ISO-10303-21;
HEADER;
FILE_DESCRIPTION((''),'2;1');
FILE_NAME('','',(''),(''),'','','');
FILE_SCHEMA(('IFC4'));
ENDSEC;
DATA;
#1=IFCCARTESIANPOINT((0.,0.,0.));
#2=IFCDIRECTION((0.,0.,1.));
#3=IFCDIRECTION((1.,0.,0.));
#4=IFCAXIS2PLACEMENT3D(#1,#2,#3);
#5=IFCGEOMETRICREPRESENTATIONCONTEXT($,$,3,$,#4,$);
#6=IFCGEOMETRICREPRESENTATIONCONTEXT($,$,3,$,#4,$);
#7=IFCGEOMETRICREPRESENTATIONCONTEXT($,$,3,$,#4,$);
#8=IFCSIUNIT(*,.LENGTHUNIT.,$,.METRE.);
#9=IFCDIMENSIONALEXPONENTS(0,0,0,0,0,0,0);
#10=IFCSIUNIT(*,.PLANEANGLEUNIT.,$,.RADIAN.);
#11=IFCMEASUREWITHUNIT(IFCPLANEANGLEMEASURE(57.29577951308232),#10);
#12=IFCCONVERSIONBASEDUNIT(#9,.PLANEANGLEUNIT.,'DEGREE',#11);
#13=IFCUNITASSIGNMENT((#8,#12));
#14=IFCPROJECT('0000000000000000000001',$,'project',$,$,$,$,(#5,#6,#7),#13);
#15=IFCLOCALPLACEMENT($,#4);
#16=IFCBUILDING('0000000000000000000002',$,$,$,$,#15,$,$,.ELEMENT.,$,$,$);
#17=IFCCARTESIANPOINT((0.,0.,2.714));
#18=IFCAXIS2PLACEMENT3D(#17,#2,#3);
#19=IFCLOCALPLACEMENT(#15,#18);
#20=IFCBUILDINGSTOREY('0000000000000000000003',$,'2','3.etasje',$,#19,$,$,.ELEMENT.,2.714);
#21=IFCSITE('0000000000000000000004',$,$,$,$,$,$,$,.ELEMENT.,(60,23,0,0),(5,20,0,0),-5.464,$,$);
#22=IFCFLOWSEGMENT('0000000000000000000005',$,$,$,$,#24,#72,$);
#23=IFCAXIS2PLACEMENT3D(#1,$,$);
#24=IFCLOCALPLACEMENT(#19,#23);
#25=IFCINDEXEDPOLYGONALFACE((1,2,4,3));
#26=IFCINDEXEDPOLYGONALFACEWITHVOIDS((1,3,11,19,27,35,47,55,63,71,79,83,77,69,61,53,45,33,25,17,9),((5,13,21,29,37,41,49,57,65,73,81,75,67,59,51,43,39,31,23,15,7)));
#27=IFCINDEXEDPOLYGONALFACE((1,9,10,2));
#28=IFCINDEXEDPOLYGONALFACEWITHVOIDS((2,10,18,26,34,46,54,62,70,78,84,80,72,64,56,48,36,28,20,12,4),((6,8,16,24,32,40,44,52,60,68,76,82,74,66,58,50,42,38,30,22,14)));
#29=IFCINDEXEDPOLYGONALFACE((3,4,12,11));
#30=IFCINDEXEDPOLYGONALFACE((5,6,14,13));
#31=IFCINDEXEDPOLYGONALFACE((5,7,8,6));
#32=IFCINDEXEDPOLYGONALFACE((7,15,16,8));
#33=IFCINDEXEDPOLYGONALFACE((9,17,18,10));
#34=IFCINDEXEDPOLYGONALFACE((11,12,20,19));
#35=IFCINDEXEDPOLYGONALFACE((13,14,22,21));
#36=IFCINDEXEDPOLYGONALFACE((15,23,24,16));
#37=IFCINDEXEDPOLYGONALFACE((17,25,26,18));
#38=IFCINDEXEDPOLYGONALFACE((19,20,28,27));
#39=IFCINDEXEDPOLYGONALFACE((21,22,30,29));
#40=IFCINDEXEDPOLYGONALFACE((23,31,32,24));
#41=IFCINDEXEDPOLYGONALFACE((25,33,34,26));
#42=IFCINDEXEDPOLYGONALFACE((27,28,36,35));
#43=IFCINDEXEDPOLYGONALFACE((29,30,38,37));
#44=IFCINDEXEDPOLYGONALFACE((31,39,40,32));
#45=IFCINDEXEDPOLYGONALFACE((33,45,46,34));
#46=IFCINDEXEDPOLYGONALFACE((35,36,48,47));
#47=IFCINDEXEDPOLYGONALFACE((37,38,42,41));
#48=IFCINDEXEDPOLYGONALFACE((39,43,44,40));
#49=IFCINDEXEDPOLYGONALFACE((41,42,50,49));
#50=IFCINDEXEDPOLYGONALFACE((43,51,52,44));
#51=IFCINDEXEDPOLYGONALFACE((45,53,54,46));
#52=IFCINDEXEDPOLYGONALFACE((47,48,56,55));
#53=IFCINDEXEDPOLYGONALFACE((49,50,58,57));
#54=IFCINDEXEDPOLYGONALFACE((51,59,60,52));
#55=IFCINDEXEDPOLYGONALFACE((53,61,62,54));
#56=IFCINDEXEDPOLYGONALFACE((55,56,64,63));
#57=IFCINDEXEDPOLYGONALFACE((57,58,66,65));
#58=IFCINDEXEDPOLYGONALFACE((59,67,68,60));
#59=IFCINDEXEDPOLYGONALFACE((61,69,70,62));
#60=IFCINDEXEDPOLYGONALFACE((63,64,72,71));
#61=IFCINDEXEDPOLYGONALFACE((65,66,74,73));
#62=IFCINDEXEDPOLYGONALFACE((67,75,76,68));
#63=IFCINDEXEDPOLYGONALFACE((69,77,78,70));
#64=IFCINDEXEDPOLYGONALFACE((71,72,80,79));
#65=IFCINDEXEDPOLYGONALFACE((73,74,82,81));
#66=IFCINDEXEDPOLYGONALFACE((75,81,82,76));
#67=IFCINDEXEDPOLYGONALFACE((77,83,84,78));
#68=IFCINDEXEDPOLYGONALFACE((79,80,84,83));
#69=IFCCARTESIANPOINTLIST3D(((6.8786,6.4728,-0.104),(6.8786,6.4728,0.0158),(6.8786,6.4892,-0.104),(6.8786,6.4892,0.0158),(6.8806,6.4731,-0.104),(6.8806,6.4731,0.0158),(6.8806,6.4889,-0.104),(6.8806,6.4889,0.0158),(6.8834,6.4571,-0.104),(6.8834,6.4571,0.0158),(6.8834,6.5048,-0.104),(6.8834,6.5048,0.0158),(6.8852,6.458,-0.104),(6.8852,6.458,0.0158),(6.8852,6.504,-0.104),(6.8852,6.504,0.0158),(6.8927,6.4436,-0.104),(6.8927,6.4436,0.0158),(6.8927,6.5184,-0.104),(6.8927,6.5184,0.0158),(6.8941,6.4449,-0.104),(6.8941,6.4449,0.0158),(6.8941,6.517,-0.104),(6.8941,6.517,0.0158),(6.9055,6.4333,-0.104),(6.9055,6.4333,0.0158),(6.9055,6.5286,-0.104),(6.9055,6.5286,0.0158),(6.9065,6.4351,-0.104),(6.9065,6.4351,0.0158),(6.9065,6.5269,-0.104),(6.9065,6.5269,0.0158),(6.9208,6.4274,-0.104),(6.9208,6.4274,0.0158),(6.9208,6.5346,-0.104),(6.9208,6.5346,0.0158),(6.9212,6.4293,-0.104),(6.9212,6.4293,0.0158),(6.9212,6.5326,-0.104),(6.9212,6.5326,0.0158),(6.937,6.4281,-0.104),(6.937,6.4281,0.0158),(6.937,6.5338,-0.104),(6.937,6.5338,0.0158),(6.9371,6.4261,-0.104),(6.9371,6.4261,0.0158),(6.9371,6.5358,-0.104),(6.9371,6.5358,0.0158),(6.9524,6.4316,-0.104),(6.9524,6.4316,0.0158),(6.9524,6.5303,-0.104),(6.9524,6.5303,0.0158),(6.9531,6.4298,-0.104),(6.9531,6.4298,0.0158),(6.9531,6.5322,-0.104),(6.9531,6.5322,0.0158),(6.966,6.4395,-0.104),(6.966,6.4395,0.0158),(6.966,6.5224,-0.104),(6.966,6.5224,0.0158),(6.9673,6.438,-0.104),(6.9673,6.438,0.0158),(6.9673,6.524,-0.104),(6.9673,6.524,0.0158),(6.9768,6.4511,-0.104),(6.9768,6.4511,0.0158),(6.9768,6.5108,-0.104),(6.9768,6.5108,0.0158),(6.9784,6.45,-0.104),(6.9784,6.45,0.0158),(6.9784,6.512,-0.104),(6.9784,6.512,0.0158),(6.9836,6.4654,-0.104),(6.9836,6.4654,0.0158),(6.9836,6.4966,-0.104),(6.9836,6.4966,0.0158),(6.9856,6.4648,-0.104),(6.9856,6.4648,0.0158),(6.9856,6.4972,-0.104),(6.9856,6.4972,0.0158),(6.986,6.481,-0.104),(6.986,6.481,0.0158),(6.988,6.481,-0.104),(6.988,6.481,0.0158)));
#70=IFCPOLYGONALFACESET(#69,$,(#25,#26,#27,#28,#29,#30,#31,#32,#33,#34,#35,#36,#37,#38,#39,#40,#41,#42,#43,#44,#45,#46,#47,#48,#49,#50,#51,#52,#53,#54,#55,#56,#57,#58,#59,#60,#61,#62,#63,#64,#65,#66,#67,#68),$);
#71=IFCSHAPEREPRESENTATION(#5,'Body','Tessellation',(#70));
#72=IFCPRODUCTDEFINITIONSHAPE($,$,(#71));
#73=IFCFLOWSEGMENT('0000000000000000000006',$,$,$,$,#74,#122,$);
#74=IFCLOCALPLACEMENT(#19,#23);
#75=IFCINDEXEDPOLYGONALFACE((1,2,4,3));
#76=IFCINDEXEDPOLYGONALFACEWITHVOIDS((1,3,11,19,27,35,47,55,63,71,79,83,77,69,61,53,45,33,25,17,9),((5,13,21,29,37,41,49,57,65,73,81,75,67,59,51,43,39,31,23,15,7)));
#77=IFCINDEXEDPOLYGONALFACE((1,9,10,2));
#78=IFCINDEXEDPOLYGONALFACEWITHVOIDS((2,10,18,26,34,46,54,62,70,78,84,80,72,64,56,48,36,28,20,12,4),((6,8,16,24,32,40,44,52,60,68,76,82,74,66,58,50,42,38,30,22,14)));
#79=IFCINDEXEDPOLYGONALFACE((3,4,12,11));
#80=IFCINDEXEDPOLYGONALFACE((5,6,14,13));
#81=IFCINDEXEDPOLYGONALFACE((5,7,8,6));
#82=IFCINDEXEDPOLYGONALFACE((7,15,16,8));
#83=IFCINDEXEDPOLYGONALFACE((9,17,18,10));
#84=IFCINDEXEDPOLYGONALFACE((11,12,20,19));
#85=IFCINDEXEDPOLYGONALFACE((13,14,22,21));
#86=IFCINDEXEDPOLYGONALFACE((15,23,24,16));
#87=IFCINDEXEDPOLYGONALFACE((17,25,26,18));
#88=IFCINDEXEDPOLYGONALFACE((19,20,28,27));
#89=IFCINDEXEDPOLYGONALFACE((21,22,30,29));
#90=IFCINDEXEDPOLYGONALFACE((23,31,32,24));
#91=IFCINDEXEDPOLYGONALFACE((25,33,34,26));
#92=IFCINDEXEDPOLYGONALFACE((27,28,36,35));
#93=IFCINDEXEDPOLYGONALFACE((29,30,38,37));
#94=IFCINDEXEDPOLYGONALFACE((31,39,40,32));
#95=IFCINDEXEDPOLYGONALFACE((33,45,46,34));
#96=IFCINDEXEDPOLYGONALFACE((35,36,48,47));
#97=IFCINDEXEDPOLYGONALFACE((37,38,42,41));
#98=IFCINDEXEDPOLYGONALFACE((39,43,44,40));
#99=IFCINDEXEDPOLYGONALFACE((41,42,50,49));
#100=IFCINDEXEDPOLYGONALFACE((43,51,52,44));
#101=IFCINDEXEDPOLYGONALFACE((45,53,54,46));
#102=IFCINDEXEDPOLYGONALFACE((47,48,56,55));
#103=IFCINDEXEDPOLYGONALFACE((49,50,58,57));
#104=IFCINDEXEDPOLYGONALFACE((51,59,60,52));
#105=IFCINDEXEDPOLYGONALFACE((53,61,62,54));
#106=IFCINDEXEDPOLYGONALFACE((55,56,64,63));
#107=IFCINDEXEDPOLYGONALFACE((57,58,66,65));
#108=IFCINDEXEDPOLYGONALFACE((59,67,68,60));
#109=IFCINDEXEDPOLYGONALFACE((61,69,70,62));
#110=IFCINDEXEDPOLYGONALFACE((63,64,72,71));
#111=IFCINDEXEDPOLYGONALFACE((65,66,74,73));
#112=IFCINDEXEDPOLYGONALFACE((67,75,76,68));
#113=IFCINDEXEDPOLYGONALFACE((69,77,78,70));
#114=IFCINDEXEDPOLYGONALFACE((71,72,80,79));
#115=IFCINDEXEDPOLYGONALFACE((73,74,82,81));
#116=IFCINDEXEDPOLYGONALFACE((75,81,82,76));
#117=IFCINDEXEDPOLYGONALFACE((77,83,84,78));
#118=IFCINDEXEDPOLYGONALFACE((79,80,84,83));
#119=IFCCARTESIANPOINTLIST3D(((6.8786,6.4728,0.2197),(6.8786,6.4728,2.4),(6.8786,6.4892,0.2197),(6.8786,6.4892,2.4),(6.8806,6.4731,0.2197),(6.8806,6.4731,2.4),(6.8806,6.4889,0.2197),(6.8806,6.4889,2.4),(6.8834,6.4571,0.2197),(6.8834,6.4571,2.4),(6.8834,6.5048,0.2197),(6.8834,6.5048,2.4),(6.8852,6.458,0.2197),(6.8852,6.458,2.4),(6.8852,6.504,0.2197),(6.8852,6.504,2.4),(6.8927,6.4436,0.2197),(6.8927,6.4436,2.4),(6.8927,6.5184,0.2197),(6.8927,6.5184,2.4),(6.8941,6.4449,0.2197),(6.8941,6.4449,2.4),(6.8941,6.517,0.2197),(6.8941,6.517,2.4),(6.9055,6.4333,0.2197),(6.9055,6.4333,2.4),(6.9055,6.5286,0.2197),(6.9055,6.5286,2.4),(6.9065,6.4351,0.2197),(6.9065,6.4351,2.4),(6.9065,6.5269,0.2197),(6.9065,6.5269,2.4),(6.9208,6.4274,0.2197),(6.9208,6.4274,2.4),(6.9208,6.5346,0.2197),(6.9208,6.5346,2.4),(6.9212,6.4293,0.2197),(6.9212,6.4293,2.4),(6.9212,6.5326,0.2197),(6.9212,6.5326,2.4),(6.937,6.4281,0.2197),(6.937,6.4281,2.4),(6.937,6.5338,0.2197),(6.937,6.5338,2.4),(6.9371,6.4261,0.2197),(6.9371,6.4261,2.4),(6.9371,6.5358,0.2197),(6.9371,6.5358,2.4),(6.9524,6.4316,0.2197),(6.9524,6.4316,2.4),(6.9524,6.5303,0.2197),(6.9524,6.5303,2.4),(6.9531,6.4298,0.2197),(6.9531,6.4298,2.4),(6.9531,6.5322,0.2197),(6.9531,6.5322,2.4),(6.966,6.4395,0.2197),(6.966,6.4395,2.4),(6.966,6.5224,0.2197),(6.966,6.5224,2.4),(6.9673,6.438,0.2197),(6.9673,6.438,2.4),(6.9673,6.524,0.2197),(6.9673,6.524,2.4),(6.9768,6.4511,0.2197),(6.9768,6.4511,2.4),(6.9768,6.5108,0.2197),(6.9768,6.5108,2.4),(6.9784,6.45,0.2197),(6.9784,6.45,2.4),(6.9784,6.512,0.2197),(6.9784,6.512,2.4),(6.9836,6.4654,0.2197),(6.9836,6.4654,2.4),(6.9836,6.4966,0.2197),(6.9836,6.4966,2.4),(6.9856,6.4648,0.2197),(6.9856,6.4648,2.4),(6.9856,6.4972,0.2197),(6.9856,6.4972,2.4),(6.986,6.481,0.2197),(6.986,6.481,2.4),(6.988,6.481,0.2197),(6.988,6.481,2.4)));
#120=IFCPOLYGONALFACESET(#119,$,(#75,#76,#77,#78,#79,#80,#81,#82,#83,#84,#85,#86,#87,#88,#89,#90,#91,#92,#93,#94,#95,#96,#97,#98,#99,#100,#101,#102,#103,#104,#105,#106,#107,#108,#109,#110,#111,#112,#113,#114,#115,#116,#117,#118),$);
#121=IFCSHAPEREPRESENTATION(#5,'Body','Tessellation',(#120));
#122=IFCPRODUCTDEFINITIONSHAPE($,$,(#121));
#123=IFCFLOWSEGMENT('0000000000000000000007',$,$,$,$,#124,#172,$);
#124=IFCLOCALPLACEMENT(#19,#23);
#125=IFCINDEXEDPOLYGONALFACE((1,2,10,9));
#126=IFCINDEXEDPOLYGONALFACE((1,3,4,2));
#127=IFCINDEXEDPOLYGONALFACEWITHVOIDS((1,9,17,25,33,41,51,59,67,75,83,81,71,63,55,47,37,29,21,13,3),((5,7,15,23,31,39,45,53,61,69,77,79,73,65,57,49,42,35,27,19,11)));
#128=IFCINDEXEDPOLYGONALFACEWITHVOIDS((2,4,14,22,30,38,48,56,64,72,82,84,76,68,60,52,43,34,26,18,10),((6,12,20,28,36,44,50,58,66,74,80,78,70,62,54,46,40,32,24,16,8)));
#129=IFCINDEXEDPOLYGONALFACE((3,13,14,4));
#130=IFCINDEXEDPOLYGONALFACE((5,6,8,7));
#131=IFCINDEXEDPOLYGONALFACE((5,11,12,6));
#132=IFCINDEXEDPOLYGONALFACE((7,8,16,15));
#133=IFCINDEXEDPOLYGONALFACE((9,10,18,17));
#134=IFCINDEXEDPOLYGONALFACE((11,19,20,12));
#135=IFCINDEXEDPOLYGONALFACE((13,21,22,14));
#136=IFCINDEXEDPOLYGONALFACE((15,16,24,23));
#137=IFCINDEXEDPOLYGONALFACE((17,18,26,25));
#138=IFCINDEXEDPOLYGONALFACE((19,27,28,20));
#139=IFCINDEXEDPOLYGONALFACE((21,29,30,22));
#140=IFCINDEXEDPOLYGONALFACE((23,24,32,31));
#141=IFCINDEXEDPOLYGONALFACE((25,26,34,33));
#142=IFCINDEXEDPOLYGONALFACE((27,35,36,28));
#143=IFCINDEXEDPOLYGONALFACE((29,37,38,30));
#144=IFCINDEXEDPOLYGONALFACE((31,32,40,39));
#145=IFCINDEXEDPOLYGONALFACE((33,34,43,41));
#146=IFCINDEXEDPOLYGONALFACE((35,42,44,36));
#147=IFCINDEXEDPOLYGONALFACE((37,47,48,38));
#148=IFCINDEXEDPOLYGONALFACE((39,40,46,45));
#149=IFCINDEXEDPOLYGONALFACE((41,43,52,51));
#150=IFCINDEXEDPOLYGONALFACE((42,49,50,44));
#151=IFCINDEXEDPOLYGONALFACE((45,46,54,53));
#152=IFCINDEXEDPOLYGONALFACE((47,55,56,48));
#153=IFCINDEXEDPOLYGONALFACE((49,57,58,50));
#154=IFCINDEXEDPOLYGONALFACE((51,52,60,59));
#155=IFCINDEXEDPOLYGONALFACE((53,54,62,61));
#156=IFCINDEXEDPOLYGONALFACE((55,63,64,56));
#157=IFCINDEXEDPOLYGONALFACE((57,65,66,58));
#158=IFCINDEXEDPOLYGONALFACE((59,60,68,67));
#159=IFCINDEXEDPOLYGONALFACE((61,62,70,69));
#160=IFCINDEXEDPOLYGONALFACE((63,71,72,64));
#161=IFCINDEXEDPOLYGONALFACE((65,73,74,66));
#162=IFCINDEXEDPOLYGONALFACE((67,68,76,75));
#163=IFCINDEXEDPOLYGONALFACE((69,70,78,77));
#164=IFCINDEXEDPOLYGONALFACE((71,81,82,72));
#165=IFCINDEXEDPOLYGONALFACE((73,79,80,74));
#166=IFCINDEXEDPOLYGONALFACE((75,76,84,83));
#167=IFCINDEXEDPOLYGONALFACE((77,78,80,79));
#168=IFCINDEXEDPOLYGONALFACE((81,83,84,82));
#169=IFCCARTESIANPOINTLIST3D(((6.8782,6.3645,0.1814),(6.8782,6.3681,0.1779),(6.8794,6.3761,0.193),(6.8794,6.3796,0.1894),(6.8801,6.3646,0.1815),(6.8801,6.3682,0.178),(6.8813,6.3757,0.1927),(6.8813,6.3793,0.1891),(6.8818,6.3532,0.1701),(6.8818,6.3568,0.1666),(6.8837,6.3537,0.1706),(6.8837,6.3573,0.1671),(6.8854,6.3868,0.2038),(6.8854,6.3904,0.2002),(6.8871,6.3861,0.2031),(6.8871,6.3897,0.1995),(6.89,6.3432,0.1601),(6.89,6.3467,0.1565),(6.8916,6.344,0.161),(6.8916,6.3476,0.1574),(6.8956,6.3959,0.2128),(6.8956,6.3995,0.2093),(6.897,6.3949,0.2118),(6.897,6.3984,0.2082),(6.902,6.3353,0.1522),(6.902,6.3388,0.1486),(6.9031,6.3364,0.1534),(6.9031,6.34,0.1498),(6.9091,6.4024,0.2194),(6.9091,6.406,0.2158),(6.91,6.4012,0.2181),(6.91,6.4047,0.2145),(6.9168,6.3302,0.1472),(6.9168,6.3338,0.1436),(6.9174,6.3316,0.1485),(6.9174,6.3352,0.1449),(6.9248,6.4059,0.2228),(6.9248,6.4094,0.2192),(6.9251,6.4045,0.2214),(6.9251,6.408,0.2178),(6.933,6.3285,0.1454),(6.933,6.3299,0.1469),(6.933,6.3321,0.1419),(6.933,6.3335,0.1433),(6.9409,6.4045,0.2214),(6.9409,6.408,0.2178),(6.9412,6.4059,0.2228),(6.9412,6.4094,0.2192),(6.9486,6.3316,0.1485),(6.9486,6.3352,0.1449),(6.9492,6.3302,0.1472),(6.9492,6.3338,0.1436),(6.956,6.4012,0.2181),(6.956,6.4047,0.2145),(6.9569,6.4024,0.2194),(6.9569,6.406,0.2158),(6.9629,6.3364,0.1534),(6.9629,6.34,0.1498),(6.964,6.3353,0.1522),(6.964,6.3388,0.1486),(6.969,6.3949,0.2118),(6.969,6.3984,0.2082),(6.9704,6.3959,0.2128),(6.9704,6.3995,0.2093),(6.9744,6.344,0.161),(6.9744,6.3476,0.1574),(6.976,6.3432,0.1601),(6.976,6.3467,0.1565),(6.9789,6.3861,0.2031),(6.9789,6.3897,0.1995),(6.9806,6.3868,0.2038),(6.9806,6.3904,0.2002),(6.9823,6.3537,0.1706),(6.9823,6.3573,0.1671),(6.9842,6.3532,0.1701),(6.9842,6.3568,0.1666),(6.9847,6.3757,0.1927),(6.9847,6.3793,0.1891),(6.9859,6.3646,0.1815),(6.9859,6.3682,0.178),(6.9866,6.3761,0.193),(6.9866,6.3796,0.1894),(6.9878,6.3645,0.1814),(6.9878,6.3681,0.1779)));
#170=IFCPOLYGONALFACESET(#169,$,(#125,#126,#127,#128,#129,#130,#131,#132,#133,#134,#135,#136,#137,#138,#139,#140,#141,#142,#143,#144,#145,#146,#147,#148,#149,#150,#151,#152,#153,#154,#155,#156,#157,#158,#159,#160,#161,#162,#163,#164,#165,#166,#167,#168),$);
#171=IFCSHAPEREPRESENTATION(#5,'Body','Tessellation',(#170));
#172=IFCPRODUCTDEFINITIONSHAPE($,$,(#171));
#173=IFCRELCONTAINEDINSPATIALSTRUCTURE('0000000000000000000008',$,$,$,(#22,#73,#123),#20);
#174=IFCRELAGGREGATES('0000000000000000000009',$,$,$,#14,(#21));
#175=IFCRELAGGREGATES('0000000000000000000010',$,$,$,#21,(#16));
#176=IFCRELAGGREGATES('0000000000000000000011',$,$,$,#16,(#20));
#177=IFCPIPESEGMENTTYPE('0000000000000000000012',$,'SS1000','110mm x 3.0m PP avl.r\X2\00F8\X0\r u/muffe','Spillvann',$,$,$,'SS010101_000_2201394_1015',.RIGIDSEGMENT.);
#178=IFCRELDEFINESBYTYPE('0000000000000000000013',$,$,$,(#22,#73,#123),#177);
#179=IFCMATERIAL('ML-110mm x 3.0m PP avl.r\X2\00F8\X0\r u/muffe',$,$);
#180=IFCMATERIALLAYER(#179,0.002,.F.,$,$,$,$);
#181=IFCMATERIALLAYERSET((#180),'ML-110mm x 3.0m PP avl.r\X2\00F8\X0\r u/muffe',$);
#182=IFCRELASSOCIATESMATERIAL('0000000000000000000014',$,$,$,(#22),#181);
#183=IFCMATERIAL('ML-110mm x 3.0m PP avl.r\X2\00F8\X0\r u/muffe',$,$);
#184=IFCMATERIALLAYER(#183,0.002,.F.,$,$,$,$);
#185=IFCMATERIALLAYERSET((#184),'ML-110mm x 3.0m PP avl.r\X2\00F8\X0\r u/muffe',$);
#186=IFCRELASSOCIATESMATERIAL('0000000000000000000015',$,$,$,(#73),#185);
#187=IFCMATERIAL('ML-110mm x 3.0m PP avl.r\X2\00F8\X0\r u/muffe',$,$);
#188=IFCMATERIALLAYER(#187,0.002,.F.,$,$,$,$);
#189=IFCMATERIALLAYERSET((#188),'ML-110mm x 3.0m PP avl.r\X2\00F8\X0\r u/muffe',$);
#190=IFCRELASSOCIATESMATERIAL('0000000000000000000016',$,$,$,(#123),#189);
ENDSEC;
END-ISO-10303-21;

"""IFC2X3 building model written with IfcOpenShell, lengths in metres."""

from ifc_helpers import new_model, entity, si_unit, converted_unit, frame, origin_with_axes, origin_2d_with_axis, place, context, project, spatial, hollow_circle, extrude, material, layer, layer_set, layer_usage, type_object, element, save


model = new_model("IFC2X3")

# Units and contexts
context_of_model_1 = context(None, 3, world=origin_with_axes())
context_of_model_2 = context(None, 3, world=origin_with_axes())
context_of_model_3 = context(None, 3, world=origin_with_axes())
ifc_project = project(units=[si_unit("LENGTHUNIT", "METRE"), converted_unit("PLANEANGLEUNIT", "DEGREE", entity("IfcPlaneAngleMeasure", 57.29577951308232), si_unit("PLANEANGLEUNIT", "RADIAN"), dimensions=[0, 0, 0, 0, 0, 0, 0])], contexts=[context_of_model_1, context_of_model_2, context_of_model_3])

# Site, building, storey
site = spatial("IfcSite", under=ifc_project, CompositionType="ELEMENT", RefLatitude=(60, 23, 0, 0), RefLongitude=(5, 20, 0, 0), RefElevation=-5.464)
building_placement = place(None, origin_with_axes())
building = spatial("IfcBuilding", under=site, at=building_placement, CompositionType="ELEMENT")
storey_placement = place(building_placement, frame((0.0, 0.0, 2.714), z_axis=(0.0, 0.0, 1.0), x_axis=(1.0, 0.0, 0.0)))
storey = spatial("IfcBuildingStorey", under=building, at=storey_placement, Name="2", Description="3.etasje", CompositionType="ELEMENT", Elevation=2.714)

# Flow segments
ifc_material_1 = material(Name="ML-110mm x 3.0m PP avl.rør u/muffe")
ifc_layer_1 = layer(ifc_material_1, 0.002, ventilated=False)
ifc_layer_set_1 = layer_set([ifc_layer_1], Name="ML-110mm x 3.0m PP avl.rør u/muffe")
ifc_layer_usage_1 = layer_usage(ifc_layer_set_1, "AXIS2", "POSITIVE", 0.0)
pipe_segment_type_1 = type_object("IfcPipeSegmentType", Name="SS1000", Description="110mm x 3.0m PP avl.rør u/muffe", ApplicableOccurrence="Spillvann", ElementType="SS010101_000_2201394_1015", PredefinedType="RIGIDSEGMENT")
flow_segment_1_placement = place(storey_placement, frame((6.933, 6.481, -0.104), z_axis=(0.0, 0.0, 1.0), x_axis=(1.0, 0.0, 0.0)))
element("IfcFlowSegment", 1, at=flow_segment_1_placement, inside=storey, type_object=pipe_segment_type_1, material=ifc_layer_usage_1, context=context_of_model_1, shape_type="SweptSolid", body=[
    extrude(hollow_circle(Radius=0.055, WallThickness=0.002, at=origin_2d_with_axis()), origin_with_axes(), (0.0, 0.0, 1.0), 0.1198),
])
ifc_material_2 = material(Name="ML-110mm x 3.0m PP avl.rør u/muffe")
ifc_layer_2 = layer(ifc_material_2, 0.002, ventilated=False)
ifc_layer_set_2 = layer_set([ifc_layer_2], Name="ML-110mm x 3.0m PP avl.rør u/muffe")
ifc_layer_usage_2 = layer_usage(ifc_layer_set_2, "AXIS2", "POSITIVE", 0.0)
flow_segment_2_placement = place(storey_placement, frame((6.933, 6.481, 0.2197), z_axis=(0.0, 0.0, 1.0), x_axis=(1.0, 0.0, 0.0)))
element("IfcFlowSegment", 2, at=flow_segment_2_placement, inside=storey, type_object=pipe_segment_type_1, material=ifc_layer_usage_2, context=context_of_model_1, shape_type="SweptSolid", body=[
    extrude(hollow_circle(Radius=0.055, WallThickness=0.002, at=origin_2d_with_axis()), origin_with_axes(), (0.0, 0.0, 1.0), 2.1803),
])
ifc_material_3 = material(Name="ML-110mm x 3.0m PP avl.rør u/muffe")
ifc_layer_3 = layer(ifc_material_3, 0.002, ventilated=False)
ifc_layer_set_3 = layer_set([ifc_layer_3], Name="ML-110mm x 3.0m PP avl.rør u/muffe")
ifc_layer_usage_3 = layer_usage(ifc_layer_set_3, "AXIS2", "POSITIVE", 0.0)
flow_segment_3_placement = place(storey_placement, frame((6.933, 6.371, 0.1808), z_axis=(0.0, -0.707107, 0.707107), x_axis=(0.0, -0.707107, -0.707107)))
element("IfcFlowSegment", 3, at=flow_segment_3_placement, inside=storey, type_object=pipe_segment_type_1, material=ifc_layer_usage_3, context=context_of_model_1, shape_type="SweptSolid", body=[
    extrude(hollow_circle(Radius=0.055, WallThickness=0.002, at=origin_2d_with_axis()), origin_with_axes(), (0.0, 0.0, 1.0), 0.0051),
])

save(model, "model.ifc")
